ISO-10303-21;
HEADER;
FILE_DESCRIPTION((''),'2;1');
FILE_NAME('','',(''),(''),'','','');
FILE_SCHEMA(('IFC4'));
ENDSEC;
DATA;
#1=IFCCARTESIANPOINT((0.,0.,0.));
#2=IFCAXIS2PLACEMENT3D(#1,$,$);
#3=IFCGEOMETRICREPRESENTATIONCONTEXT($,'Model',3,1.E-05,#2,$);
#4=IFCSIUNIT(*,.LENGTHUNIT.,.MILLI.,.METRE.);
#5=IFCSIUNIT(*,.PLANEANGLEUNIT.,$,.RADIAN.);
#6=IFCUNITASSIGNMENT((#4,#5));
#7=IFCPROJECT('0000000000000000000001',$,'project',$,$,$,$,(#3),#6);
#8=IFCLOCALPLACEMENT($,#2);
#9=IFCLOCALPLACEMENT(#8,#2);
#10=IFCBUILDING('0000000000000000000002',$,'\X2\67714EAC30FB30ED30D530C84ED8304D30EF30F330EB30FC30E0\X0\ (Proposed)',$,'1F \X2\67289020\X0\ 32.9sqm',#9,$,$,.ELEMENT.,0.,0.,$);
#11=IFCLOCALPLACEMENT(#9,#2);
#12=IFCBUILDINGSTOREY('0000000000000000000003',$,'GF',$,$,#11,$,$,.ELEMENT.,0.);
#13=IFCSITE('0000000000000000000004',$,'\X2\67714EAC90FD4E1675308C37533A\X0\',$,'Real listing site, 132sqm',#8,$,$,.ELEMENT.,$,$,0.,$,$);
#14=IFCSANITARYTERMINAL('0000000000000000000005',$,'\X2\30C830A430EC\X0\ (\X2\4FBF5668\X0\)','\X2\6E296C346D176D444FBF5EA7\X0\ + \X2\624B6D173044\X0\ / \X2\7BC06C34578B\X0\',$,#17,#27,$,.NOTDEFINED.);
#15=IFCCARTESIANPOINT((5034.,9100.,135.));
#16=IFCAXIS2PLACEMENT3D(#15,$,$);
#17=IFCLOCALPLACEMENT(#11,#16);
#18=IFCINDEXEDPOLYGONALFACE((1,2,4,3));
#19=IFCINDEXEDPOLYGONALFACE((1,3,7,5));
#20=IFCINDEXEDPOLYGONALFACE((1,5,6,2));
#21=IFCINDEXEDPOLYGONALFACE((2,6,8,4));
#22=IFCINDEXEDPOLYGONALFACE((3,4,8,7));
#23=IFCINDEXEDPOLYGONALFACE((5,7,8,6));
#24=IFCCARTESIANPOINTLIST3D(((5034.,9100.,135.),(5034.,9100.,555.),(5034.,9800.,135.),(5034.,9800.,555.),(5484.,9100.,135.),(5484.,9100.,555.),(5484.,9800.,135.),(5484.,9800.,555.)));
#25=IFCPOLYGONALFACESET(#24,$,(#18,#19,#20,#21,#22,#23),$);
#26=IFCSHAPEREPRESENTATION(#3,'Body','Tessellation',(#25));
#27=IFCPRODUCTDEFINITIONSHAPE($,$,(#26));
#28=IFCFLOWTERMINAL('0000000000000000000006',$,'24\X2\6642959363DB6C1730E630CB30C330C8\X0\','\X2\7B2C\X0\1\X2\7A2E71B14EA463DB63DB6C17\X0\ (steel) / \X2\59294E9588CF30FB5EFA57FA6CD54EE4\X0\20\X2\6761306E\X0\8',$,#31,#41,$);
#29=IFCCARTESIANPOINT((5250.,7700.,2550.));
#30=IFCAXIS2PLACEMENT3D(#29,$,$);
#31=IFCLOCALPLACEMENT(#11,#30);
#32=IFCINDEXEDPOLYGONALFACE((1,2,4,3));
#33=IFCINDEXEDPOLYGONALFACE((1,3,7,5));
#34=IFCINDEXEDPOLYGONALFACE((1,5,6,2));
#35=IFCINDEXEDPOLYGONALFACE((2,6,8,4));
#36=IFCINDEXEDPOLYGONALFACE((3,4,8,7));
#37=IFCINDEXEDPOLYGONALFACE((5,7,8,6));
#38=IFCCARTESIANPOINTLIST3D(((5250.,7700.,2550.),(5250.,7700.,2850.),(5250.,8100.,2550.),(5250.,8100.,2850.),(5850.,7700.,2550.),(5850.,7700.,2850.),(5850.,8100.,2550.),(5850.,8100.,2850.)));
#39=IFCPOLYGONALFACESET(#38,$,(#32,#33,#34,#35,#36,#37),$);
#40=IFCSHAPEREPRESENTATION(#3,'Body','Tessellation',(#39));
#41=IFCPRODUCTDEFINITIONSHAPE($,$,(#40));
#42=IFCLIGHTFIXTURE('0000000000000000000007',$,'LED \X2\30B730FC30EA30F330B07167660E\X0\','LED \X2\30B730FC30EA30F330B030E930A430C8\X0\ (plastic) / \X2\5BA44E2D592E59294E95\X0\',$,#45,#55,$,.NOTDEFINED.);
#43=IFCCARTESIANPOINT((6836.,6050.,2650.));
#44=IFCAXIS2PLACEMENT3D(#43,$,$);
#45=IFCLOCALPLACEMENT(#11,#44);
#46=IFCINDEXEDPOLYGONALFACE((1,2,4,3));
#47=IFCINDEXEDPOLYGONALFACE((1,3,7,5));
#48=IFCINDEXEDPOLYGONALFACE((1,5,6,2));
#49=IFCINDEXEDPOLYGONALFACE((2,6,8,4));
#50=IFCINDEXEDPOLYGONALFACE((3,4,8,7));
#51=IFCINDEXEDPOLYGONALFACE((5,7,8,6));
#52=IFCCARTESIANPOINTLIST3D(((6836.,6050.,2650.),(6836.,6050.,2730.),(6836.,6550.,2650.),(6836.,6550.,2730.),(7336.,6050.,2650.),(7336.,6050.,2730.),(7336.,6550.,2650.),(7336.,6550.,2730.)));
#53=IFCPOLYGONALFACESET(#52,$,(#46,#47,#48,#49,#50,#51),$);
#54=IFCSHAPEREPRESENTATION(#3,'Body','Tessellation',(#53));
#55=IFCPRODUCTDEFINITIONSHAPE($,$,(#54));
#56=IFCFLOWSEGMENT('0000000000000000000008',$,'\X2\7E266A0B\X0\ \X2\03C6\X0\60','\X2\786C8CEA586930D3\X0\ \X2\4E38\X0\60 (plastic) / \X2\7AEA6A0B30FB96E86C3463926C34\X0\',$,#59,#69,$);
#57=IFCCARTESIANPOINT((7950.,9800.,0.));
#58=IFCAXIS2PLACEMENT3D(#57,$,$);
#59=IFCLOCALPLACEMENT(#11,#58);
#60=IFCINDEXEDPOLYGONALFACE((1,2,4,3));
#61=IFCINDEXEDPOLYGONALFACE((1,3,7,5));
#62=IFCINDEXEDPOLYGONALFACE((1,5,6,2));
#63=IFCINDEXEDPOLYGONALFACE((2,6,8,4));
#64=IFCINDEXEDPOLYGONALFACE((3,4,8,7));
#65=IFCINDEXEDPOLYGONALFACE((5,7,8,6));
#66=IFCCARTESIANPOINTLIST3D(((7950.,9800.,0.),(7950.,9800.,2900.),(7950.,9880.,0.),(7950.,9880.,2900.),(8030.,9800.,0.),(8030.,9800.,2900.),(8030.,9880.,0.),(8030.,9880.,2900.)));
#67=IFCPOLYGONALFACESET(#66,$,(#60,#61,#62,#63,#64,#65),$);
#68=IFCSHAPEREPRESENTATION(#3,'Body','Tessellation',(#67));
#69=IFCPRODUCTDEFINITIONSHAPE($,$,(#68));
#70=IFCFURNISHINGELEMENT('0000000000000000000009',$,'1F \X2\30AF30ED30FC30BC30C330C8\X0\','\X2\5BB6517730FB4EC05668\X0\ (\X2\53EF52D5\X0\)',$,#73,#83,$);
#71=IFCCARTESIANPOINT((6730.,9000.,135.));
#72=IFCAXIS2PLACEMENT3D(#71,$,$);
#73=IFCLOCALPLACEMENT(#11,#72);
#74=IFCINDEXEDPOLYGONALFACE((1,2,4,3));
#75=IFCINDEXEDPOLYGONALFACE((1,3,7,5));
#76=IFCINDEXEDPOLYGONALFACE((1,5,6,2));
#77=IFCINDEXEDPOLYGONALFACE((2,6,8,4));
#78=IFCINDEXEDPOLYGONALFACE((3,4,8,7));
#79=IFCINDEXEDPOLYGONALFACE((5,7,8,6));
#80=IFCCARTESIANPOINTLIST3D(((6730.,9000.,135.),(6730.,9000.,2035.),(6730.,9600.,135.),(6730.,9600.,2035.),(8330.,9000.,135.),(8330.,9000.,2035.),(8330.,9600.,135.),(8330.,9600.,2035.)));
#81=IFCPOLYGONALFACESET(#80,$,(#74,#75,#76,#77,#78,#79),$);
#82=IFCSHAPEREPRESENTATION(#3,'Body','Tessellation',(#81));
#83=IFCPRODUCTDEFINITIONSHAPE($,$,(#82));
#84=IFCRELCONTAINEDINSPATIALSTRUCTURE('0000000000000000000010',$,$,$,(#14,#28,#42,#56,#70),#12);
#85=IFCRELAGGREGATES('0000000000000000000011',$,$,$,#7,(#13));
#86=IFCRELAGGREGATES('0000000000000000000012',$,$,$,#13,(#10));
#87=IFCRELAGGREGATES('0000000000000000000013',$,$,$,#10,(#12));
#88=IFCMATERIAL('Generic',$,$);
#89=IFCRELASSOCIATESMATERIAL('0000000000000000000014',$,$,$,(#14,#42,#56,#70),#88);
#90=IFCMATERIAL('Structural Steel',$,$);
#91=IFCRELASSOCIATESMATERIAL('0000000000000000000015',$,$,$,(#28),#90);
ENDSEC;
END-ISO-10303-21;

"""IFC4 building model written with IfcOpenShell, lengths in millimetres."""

from ifc_helpers import new_model, si_unit, frame, frame_2d, origin, place, context, project, spatial, rectangle, extrude, material, element, save


model = new_model("IFC4")

# Units and contexts
model_context = context("Model", 3, precision=1e-05, world=origin())
ifc_project = project(units=[si_unit("LENGTHUNIT", "METRE", prefix="MILLI"), si_unit("PLANEANGLEUNIT", "RADIAN")], contexts=[model_context])

# Site, building, storey
site_placement = place(None, origin())
site = spatial("IfcSite", under=ifc_project, at=site_placement, Name="東京都世田谷区", ObjectType="Real listing site, 132sqm", CompositionType="ELEMENT", RefElevation=0.0)
building_placement = place(site_placement, origin())
building = spatial("IfcBuilding", under=site, at=building_placement, Name="東京・ロフト付きワンルーム (Proposed)", ObjectType="1F 木造 32.9sqm", CompositionType="ELEMENT", ElevationOfRefHeight=0.0, ElevationOfTerrain=0.0)
storey_placement = place(building_placement, origin())
storey = spatial("IfcBuildingStorey", under=building, at=storey_placement, Name="GF", CompositionType="ELEMENT", Elevation=0.0)

# Shared definitions
ifc_material_1 = material(Name="Generic")

# Sanitary terminal
sanitary_terminal_1_placement = place(storey_placement, frame((5034.0, 9100.0, 135.0)))
element("IfcSanitaryTerminal", 1, at=sanitary_terminal_1_placement, inside=storey, material=ifc_material_1, Name="トイレ (便器)", Description="温水洗浄便座 + 手洗い / 節水型", PredefinedType="NOTDEFINED", context=model_context, shape_type="SweptSolid", body=[
    extrude(rectangle(XDim=450.0, YDim=700.0, at=frame_2d((225.0, 350.0))), frame((5034.0, 9100.0, 135.0)), (0.0, 0.0, 1.0), 420.0),
])

# Flow terminal
ifc_material_2 = material(Name="Structural Steel")
flow_terminal_placement = place(storey_placement, frame((5250.0, 7700.0, 2550.0)))
element("IfcFlowTerminal", 2, at=flow_terminal_placement, inside=storey, material=ifc_material_2, Name="24時間換気ユニット", Description="第1種熱交換換気 (steel) / 天井裏・建基法令20条の8", context=model_context, shape_type="SweptSolid", body=[
    extrude(rectangle(XDim=600.0, YDim=400.0, at=frame_2d((300.0, 200.0))), frame((5250.0, 7700.0, 2550.0)), (0.0, 0.0, 1.0), 300.0),
])

# Light fixture
light_fixture_placement = place(storey_placement, frame((6836.0, 6050.0, 2650.0)))
element("IfcLightFixture", 3, at=light_fixture_placement, inside=storey, material=ifc_material_1, Name="LED シーリング照明", Description="LED シーリングライト (plastic) / 室中央天井", PredefinedType="NOTDEFINED", context=model_context, shape_type="SweptSolid", body=[
    extrude(rectangle(XDim=500.0, YDim=500.0, at=frame_2d((250.0, 250.0))), frame((6836.0, 6050.0, 2650.0)), (0.0, 0.0, 1.0), 80.0),
])

# Flow segment
flow_segment_placement = place(storey_placement, frame((7950.0, 9800.0, 0.0)))
element("IfcFlowSegment", 4, at=flow_segment_placement, inside=storey, material=ifc_material_1, Name="縦樋 φ60", Description="硬質塩ビ 丸60 (plastic) / 竪樋・雨水排水", context=model_context, shape_type="SweptSolid", body=[
    extrude(rectangle(XDim=80.0, YDim=80.0, at=frame_2d((40.0, 40.0))), frame((7950.0, 9800.0, 0.0)), (0.0, 0.0, 1.0), 2900.0),
])

# Furnishing element
furnishing_placement = place(storey_placement, frame((6730.0, 9000.0, 135.0)))
element("IfcFurnishingElement", 5, at=furnishing_placement, inside=storey, material=ifc_material_1, Name="1F クローゼット", Description="家具・什器 (可動)", context=model_context, shape_type="SweptSolid", body=[
    extrude(rectangle(XDim=1600.0, YDim=600.0, at=frame_2d((800.0, 300.0))), frame((6730.0, 9000.0, 135.0)), (0.0, 0.0, 1.0), 1900.0),
])

save(model, "model.ifc")
